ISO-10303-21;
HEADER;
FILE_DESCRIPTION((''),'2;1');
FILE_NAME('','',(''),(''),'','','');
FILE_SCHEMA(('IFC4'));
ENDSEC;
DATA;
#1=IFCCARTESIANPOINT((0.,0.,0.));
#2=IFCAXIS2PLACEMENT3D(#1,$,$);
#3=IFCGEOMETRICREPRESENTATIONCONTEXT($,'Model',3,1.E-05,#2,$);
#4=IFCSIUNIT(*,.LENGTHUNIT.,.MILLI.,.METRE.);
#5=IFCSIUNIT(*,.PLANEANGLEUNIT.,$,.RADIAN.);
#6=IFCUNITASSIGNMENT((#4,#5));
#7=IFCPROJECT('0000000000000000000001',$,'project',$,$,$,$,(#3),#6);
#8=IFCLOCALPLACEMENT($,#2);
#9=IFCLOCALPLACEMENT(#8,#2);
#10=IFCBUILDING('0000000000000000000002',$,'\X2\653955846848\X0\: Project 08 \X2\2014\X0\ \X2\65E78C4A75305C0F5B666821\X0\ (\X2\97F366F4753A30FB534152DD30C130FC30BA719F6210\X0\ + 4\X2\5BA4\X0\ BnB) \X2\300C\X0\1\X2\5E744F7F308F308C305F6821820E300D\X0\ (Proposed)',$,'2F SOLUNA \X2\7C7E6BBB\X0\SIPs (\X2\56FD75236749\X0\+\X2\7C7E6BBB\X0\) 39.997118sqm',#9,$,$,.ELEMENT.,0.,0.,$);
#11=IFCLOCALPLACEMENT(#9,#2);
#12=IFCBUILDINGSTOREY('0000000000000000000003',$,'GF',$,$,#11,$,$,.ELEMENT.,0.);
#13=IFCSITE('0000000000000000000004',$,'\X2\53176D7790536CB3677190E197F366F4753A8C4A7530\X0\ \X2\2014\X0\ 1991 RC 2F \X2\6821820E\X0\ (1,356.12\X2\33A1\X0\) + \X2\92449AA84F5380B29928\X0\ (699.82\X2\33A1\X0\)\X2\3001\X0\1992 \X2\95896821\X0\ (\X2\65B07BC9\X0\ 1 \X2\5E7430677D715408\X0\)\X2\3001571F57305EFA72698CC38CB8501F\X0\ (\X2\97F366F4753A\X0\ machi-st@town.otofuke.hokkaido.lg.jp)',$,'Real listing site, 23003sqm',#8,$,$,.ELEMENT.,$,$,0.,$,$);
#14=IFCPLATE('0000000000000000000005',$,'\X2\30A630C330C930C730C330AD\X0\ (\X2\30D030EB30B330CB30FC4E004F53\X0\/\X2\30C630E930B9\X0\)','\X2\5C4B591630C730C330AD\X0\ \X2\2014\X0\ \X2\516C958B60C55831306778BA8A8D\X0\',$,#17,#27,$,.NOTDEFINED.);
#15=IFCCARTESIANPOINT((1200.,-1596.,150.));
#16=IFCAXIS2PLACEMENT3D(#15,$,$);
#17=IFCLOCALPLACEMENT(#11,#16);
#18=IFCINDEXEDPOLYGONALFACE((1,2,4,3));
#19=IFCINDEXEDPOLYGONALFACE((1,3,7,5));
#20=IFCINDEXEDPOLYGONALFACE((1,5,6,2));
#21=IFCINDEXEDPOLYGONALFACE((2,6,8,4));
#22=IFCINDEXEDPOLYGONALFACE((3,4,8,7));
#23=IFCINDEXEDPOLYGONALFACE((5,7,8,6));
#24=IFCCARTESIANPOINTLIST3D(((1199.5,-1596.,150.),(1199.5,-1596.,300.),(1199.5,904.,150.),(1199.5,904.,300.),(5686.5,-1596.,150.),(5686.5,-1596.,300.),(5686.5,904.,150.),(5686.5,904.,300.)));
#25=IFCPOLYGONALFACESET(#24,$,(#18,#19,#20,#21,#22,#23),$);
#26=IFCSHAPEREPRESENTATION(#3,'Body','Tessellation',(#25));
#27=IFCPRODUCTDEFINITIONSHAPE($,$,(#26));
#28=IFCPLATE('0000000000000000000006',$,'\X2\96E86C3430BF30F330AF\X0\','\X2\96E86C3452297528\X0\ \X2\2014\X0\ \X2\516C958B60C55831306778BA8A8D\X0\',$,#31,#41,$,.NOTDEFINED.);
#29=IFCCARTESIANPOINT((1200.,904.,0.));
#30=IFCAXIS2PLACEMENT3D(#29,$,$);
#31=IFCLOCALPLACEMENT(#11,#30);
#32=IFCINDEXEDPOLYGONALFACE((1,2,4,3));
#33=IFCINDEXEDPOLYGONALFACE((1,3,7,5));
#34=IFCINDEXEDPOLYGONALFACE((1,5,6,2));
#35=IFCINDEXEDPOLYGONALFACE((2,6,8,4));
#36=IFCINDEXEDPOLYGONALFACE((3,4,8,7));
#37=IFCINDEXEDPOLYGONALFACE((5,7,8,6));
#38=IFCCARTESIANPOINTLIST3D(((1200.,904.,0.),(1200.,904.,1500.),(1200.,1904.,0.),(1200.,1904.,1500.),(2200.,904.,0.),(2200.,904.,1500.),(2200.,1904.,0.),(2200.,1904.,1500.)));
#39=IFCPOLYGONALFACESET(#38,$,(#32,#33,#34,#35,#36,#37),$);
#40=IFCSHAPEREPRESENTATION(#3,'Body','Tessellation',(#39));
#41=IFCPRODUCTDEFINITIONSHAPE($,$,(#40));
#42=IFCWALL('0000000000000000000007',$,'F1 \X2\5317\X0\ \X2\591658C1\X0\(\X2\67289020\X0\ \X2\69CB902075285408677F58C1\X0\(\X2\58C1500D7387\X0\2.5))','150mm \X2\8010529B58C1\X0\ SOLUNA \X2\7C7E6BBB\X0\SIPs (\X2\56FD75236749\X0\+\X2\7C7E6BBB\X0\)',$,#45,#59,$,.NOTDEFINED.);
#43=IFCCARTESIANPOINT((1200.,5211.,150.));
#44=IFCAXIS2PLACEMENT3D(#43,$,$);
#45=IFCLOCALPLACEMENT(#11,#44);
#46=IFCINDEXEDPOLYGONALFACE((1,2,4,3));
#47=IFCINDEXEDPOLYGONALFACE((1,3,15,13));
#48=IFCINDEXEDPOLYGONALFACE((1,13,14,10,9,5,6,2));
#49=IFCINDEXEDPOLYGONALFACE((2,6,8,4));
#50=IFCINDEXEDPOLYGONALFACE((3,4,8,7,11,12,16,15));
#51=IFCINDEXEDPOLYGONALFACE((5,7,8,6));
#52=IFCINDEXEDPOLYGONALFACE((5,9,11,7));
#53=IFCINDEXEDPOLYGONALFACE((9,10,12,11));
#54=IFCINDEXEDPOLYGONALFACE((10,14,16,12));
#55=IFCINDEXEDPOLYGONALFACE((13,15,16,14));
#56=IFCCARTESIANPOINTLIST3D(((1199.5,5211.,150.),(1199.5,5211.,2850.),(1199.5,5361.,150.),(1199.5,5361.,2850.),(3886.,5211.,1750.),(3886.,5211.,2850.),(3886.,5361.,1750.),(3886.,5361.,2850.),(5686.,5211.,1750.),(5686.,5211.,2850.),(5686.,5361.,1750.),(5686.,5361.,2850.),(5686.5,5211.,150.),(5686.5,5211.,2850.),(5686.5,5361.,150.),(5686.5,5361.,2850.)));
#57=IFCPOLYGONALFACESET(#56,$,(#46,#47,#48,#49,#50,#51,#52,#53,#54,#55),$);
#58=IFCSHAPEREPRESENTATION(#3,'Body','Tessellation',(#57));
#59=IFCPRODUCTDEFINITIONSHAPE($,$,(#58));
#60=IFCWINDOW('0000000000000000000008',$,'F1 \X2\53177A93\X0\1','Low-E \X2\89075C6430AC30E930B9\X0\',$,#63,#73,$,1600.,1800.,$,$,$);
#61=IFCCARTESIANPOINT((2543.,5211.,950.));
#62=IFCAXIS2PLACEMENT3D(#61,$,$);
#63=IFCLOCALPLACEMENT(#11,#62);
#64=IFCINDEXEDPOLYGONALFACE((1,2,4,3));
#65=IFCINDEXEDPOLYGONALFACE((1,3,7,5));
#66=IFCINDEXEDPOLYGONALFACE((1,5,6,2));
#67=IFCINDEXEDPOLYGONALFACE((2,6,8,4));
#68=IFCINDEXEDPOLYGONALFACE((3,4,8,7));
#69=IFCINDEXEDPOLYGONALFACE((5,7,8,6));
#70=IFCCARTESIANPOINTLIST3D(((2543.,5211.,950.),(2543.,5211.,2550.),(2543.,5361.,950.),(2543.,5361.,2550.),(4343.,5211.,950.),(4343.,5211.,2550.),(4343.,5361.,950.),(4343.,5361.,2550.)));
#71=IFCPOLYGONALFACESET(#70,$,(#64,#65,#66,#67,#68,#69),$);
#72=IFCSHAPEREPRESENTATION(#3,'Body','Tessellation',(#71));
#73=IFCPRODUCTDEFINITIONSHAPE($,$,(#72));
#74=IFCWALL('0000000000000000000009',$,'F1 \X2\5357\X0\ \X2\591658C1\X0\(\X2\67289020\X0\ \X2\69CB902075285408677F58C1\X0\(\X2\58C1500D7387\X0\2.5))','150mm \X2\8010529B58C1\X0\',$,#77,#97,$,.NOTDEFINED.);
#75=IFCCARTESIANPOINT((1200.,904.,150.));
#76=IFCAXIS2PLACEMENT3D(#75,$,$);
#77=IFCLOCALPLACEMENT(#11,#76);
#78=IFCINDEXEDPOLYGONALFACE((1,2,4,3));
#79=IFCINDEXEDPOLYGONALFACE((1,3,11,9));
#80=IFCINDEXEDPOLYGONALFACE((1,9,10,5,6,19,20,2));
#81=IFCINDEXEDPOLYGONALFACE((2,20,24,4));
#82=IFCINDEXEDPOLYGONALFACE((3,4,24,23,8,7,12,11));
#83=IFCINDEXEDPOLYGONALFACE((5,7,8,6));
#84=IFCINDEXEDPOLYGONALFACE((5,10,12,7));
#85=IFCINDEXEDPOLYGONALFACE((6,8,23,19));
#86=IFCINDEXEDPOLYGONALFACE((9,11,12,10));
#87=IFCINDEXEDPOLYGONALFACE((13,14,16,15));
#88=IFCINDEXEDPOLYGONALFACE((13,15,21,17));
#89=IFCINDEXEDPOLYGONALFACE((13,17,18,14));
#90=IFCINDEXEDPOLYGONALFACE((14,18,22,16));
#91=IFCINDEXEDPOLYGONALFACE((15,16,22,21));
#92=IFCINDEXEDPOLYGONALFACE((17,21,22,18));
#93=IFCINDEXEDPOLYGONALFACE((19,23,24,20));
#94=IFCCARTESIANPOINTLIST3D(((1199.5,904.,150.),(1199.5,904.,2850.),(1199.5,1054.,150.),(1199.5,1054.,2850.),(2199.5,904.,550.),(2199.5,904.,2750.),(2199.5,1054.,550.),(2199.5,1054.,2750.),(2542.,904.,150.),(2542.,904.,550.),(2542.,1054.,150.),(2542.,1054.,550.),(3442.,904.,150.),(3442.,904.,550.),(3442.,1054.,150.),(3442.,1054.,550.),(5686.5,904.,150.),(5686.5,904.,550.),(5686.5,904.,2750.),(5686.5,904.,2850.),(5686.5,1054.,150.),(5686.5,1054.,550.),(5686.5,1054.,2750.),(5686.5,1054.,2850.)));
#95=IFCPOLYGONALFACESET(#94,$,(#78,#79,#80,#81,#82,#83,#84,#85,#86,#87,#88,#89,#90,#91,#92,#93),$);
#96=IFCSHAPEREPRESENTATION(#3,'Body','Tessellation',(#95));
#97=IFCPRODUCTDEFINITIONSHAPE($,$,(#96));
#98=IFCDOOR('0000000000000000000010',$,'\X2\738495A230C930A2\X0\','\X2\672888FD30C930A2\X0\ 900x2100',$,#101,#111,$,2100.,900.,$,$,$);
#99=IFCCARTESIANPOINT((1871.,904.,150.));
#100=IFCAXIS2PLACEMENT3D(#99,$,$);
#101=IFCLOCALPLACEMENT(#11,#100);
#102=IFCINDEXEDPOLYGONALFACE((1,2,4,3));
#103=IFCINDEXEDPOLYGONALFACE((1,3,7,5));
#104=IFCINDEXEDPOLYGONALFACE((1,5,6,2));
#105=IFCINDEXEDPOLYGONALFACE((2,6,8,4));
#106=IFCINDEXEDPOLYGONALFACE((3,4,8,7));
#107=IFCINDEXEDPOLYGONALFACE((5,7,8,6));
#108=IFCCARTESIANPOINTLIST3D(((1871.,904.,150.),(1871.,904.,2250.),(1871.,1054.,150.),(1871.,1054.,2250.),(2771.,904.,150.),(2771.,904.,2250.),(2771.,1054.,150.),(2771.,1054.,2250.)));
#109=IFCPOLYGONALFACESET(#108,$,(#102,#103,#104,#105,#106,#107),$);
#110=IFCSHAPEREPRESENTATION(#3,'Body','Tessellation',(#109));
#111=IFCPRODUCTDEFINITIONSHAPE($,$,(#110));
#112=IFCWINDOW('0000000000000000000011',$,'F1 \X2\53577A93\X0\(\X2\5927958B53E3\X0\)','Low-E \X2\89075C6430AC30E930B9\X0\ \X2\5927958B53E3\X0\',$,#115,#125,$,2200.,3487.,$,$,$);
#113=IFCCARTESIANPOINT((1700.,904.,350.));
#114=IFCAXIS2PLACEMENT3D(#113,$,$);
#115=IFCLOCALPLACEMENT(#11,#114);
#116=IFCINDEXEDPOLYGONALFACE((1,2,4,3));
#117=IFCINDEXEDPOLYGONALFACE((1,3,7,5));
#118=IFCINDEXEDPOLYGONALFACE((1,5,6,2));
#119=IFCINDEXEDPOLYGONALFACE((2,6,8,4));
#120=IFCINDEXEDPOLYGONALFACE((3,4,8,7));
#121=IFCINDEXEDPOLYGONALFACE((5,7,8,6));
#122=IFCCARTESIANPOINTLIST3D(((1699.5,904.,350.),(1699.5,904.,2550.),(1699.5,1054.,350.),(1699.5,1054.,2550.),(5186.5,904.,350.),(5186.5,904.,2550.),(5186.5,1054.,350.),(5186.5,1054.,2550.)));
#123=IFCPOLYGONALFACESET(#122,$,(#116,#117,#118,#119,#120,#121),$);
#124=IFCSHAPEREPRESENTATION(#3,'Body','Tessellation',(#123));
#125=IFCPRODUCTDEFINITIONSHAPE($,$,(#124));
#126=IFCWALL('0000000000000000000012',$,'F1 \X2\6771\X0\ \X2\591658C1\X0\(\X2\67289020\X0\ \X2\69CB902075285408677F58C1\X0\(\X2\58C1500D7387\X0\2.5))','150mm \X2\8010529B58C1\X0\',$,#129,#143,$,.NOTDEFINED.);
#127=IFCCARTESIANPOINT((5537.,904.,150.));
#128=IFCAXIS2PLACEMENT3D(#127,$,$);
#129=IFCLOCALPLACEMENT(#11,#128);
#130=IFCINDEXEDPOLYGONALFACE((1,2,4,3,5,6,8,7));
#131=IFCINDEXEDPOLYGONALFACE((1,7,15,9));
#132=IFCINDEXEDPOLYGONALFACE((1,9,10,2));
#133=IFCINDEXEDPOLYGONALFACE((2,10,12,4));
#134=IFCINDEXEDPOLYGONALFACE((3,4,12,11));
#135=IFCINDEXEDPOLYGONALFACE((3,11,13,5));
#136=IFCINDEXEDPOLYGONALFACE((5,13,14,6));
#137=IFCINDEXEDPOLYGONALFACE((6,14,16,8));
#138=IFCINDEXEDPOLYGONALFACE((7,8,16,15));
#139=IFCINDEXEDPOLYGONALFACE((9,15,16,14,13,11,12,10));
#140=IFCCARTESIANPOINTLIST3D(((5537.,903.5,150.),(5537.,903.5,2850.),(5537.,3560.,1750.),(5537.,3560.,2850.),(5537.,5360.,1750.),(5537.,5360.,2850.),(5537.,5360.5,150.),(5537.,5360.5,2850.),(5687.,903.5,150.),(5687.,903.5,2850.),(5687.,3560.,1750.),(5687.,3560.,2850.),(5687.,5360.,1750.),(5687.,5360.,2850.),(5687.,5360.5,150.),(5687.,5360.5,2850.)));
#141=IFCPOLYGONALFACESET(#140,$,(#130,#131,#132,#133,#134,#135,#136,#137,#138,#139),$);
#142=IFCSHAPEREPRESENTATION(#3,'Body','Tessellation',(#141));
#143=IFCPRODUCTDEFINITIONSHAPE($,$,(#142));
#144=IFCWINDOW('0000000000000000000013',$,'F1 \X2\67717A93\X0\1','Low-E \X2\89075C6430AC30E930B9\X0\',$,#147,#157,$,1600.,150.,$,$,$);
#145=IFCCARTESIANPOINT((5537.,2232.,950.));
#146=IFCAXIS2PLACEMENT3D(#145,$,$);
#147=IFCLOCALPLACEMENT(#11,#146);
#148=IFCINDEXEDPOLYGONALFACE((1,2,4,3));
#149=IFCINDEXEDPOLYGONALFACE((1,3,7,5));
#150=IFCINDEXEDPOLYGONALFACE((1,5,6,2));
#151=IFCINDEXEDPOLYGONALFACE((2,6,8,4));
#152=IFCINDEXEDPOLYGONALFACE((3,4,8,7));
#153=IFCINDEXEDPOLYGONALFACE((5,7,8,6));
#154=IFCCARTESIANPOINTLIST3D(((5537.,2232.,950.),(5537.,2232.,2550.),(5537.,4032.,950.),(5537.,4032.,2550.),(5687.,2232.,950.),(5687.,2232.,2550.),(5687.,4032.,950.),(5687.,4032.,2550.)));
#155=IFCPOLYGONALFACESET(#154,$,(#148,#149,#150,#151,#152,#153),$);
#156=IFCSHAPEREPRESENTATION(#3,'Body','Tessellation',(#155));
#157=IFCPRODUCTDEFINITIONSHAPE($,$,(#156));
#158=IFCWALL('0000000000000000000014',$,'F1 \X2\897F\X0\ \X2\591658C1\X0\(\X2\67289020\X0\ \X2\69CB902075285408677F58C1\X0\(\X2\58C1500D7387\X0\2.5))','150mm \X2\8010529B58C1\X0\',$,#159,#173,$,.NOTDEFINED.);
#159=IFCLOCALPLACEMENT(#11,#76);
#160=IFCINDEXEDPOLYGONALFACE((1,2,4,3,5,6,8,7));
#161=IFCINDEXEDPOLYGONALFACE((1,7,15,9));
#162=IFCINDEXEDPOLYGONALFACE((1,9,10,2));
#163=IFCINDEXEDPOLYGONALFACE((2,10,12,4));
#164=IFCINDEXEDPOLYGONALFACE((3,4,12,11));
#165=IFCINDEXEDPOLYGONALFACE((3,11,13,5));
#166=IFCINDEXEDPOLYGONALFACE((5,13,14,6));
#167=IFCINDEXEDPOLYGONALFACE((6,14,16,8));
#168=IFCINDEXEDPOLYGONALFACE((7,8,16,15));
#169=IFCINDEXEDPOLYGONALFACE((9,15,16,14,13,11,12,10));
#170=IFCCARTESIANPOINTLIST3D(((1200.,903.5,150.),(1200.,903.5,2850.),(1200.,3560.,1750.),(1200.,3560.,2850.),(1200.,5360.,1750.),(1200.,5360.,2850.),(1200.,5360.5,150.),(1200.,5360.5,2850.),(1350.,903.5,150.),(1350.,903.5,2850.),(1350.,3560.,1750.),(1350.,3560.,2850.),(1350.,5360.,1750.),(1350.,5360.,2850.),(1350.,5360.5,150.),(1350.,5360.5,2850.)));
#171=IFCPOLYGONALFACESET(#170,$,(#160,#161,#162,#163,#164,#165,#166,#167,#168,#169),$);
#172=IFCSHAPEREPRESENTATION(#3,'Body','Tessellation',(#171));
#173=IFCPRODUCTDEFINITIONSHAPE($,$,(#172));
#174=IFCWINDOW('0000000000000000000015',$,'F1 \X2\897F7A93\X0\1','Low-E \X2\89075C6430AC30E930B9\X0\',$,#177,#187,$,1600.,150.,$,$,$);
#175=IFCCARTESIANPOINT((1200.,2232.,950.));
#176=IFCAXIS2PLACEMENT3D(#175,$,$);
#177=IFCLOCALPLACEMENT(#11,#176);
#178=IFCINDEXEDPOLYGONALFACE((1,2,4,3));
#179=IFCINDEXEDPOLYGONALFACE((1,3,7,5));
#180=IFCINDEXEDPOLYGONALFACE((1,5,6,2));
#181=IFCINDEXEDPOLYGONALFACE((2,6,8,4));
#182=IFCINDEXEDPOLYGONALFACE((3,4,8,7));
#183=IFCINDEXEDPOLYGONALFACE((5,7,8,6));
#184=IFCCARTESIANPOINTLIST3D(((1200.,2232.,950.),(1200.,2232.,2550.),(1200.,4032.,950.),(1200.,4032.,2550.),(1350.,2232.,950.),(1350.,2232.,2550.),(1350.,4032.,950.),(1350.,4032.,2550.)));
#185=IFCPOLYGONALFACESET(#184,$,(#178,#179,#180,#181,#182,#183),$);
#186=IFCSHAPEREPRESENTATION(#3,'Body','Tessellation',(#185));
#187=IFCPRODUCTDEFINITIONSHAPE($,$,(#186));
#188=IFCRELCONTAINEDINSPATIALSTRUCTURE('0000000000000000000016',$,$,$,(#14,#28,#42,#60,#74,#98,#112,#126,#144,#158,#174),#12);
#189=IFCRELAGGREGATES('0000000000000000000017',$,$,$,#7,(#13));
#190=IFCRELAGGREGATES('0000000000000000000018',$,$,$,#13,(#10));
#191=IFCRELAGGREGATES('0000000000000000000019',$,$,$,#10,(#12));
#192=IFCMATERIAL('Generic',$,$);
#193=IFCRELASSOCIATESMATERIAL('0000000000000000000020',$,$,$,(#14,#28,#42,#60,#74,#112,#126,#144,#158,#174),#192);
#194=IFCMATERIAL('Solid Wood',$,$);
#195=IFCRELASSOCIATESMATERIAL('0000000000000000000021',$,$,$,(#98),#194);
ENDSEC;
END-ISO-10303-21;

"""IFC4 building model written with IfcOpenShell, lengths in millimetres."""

from ifc_helpers import new_model, si_unit, frame, frame_2d, origin, place, context, project, spatial, rectangle, extrude, material, element, fill, save


model = new_model("IFC4")

# Units and contexts
model_context = context("Model", 3, precision=1e-05, world=origin())
ifc_project = project(units=[si_unit("LENGTHUNIT", "METRE", prefix="MILLI"), si_unit("PLANEANGLEUNIT", "RADIAN")], contexts=[model_context])

# Site, building, storey
site_placement = place(None, origin())
site = spatial("IfcSite", under=ifc_project, at=site_placement, Name="北海道河東郡音更町豊田 — 1991 RC 2F 校舎 (1,356.12㎡) + 鉄骨体育館 (699.82㎡)、1992 閉校 (新築 1 年で統合)、土地建物賃貸借 (音更町 machi-st@town.otofuke.hokkaido.lg.jp)", ObjectType="Real listing site, 23003sqm", CompositionType="ELEMENT", RefElevation=0.0)
building_placement = place(site_placement, origin())
building = spatial("IfcBuilding", under=site, at=building_placement, Name="改善案: Project 08 — 旧豊田小学校 (音更町・十勝チーズ熟成 + 4室 BnB) 「1年使われた校舎」 (Proposed)", ObjectType="2F SOLUNA 籾殻SIPs (国産杉+籾殻) 39.997118sqm", CompositionType="ELEMENT", ElevationOfRefHeight=0.0, ElevationOfTerrain=0.0)
storey_placement = place(building_placement, origin())
storey = spatial("IfcBuildingStorey", under=building, at=storey_placement, Name="GF", CompositionType="ELEMENT", Elevation=0.0)

# Shared definitions
ifc_material_1 = material(Name="Generic")

# Plates
plate_1_placement = place(storey_placement, frame((1200.0, -1596.0, 150.0)))
element("IfcPlate", 1, at=plate_1_placement, inside=storey, material=ifc_material_1, Name="ウッドデッキ (バルコニー一体/テラス)", Description="屋外デッキ — 公開情報で確認", PredefinedType="NOTDEFINED", context=model_context, shape_type="SweptSolid", body=[
    extrude(rectangle(XDim=4487.0, YDim=2500.0, at=frame_2d((2243.0, 1250.0))), frame((1200.0, -1596.0, 150.0)), (0.0, 0.0, 1.0), 150.0),
])
plate_2_placement = place(storey_placement, frame((1200.0, 904.0, 0.0)))
element("IfcPlate", 2, at=plate_2_placement, inside=storey, material=ifc_material_1, Name="雨水タンク", Description="雨水利用 — 公開情報で確認", PredefinedType="NOTDEFINED", context=model_context, shape_type="SweptSolid", body=[
    extrude(rectangle(XDim=1000.0, YDim=1000.0, at=frame_2d((500.0, 500.0))), frame((1200.0, 904.0, 0.0)), (0.0, 0.0, 1.0), 1500.0),
])

# Wall, opening, window
wall_1_placement = place(storey_placement, frame((1200.0, 5211.0, 150.0)))
wall_1 = element("IfcWall", 3, at=wall_1_placement, inside=storey, material=ifc_material_1, Name="F1 北 外壁(木造 構造用合板壁(壁倍率2.5))", Description="150mm 耐力壁 SOLUNA 籾殻SIPs (国産杉+籾殻)", PredefinedType="NOTDEFINED", context=model_context, shape_type="SweptSolid", body=[
    extrude(rectangle(XDim=4487.0, YDim=150.0, at=frame_2d((2243.0, 75.0))), frame((1200.0, 5211.0, 150.0)), (0.0, 0.0, 1.0), 2700.0),
])
opening_1_placement = place(storey_placement, frame((2543.0, 5211.0, 950.0)))
opening_1 = element("IfcOpeningElement", 4, at=opening_1_placement, cuts=wall_1, PredefinedType="NOTDEFINED", context=model_context, shape_type="SweptSolid", body=[
    extrude(rectangle(XDim=1800.0, YDim=150.0, at=frame_2d((900.0, 75.0))), frame((2543.0, 5211.0, 950.0)), (0.0, 0.0, 1.0), 1600.0),
])
window_1_placement = place(storey_placement, frame((2543.0, 5211.0, 950.0)))
window_1 = element("IfcWindow", 5, at=window_1_placement, inside=storey, material=ifc_material_1, Name="F1 北窓1", Description="Low-E 複層ガラス", OverallHeight=1600.0, OverallWidth=1800.0, context=model_context, shape_type="SweptSolid", body=[
    extrude(rectangle(XDim=1800.0, YDim=150.0, at=frame_2d((900.0, 75.0))), frame((2543.0, 5211.0, 950.0)), (0.0, 0.0, 1.0), 1600.0),
])
fill(opening_1, window_1)

# Wall, openings, door, window
wall_2_placement = place(storey_placement, frame((1200.0, 904.0, 150.0)))
wall_2 = element("IfcWall", 6, at=wall_2_placement, inside=storey, material=ifc_material_1, Name="F1 南 外壁(木造 構造用合板壁(壁倍率2.5))", Description="150mm 耐力壁", PredefinedType="NOTDEFINED", context=model_context, shape_type="SweptSolid", body=[
    extrude(rectangle(XDim=4487.0, YDim=150.0, at=frame_2d((2243.0, 75.0))), frame((1200.0, 904.0, 150.0)), (0.0, 0.0, 1.0), 2700.0),
])
opening_2_placement = place(storey_placement, frame((1871.0, 904.0, 150.0)))
opening_2 = element("IfcOpeningElement", 7, at=opening_2_placement, cuts=wall_2, PredefinedType="NOTDEFINED", context=model_context, shape_type="SweptSolid", body=[
    extrude(rectangle(XDim=900.0, YDim=150.0, at=frame_2d((450.0, 75.0))), frame((1871.0, 904.0, 150.0)), (0.0, 0.0, 1.0), 2100.0),
])
opening_3_placement = place(storey_placement, frame((1700.0, 904.0, 350.0)))
opening_3 = element("IfcOpeningElement", 8, at=opening_3_placement, cuts=wall_2, PredefinedType="NOTDEFINED", context=model_context, shape_type="SweptSolid", body=[
    extrude(rectangle(XDim=3487.0, YDim=150.0, at=frame_2d((1743.0, 75.0))), frame((1700.0, 904.0, 350.0)), (0.0, 0.0, 1.0), 2200.0),
])
ifc_material_2 = material(Name="Solid Wood")
door_placement = place(storey_placement, frame((1871.0, 904.0, 150.0)))
door = element("IfcDoor", 9, at=door_placement, inside=storey, material=ifc_material_2, Name="玄関ドア", Description="木製ドア 900x2100", OverallHeight=2100.0, OverallWidth=900.0, context=model_context, shape_type="SweptSolid", body=[
    extrude(rectangle(XDim=900.0, YDim=150.0, at=frame_2d((450.0, 75.0))), frame((1871.0, 904.0, 150.0)), (0.0, 0.0, 1.0), 2100.0),
])
fill(opening_2, door)
window_2_placement = place(storey_placement, frame((1700.0, 904.0, 350.0)))
window_2 = element("IfcWindow", 10, at=window_2_placement, inside=storey, material=ifc_material_1, Name="F1 南窓(大開口)", Description="Low-E 複層ガラス 大開口", OverallHeight=2200.0, OverallWidth=3487.0, context=model_context, shape_type="SweptSolid", body=[
    extrude(rectangle(XDim=3487.0, YDim=150.0, at=frame_2d((1743.0, 75.0))), frame((1700.0, 904.0, 350.0)), (0.0, 0.0, 1.0), 2200.0),
])
fill(opening_3, window_2)

# Walls, openings, windows
wall_3_placement = place(storey_placement, frame((5537.0, 904.0, 150.0)))
wall_3 = element("IfcWall", 11, at=wall_3_placement, inside=storey, material=ifc_material_1, Name="F1 東 外壁(木造 構造用合板壁(壁倍率2.5))", Description="150mm 耐力壁", PredefinedType="NOTDEFINED", context=model_context, shape_type="SweptSolid", body=[
    extrude(rectangle(XDim=150.0, YDim=4457.0, at=frame_2d((75.0, 2228.0))), frame((5537.0, 904.0, 150.0)), (0.0, 0.0, 1.0), 2700.0),
])
opening_4_placement = place(storey_placement, frame((5537.0, 2232.0, 950.0)))
opening_4 = element("IfcOpeningElement", 12, at=opening_4_placement, cuts=wall_3, PredefinedType="NOTDEFINED", context=model_context, shape_type="SweptSolid", body=[
    extrude(rectangle(XDim=150.0, YDim=1800.0, at=frame_2d((75.0, 900.0))), frame((5537.0, 2232.0, 950.0)), (0.0, 0.0, 1.0), 1600.0),
])
window_3_placement = place(storey_placement, frame((5537.0, 2232.0, 950.0)))
window_3 = element("IfcWindow", 13, at=window_3_placement, inside=storey, material=ifc_material_1, Name="F1 東窓1", Description="Low-E 複層ガラス", OverallHeight=1600.0, OverallWidth=150.0, context=model_context, shape_type="SweptSolid", body=[
    extrude(rectangle(XDim=150.0, YDim=1800.0, at=frame_2d((75.0, 900.0))), frame((5537.0, 2232.0, 950.0)), (0.0, 0.0, 1.0), 1600.0),
])
fill(opening_4, window_3)
wall_4_placement = place(storey_placement, frame((1200.0, 904.0, 150.0)))
wall_4 = element("IfcWall", 14, at=wall_4_placement, inside=storey, material=ifc_material_1, Name="F1 西 外壁(木造 構造用合板壁(壁倍率2.5))", Description="150mm 耐力壁", PredefinedType="NOTDEFINED", context=model_context, shape_type="SweptSolid", body=[
    extrude(rectangle(XDim=150.0, YDim=4457.0, at=frame_2d((75.0, 2228.0))), frame((1200.0, 904.0, 150.0)), (0.0, 0.0, 1.0), 2700.0),
])
opening_5_placement = place(storey_placement, frame((1200.0, 2232.0, 950.0)))
opening_5 = element("IfcOpeningElement", 15, at=opening_5_placement, cuts=wall_4, PredefinedType="NOTDEFINED", context=model_context, shape_type="SweptSolid", body=[
    extrude(rectangle(XDim=150.0, YDim=1800.0, at=frame_2d((75.0, 900.0))), frame((1200.0, 2232.0, 950.0)), (0.0, 0.0, 1.0), 1600.0),
])
window_4_placement = place(storey_placement, frame((1200.0, 2232.0, 950.0)))
window_4 = element("IfcWindow", 16, at=window_4_placement, inside=storey, material=ifc_material_1, Name="F1 西窓1", Description="Low-E 複層ガラス", OverallHeight=1600.0, OverallWidth=150.0, context=model_context, shape_type="SweptSolid", body=[
    extrude(rectangle(XDim=150.0, YDim=1800.0, at=frame_2d((75.0, 900.0))), frame((1200.0, 2232.0, 950.0)), (0.0, 0.0, 1.0), 1600.0),
])
fill(opening_5, window_4)

save(model, "model.ifc")
